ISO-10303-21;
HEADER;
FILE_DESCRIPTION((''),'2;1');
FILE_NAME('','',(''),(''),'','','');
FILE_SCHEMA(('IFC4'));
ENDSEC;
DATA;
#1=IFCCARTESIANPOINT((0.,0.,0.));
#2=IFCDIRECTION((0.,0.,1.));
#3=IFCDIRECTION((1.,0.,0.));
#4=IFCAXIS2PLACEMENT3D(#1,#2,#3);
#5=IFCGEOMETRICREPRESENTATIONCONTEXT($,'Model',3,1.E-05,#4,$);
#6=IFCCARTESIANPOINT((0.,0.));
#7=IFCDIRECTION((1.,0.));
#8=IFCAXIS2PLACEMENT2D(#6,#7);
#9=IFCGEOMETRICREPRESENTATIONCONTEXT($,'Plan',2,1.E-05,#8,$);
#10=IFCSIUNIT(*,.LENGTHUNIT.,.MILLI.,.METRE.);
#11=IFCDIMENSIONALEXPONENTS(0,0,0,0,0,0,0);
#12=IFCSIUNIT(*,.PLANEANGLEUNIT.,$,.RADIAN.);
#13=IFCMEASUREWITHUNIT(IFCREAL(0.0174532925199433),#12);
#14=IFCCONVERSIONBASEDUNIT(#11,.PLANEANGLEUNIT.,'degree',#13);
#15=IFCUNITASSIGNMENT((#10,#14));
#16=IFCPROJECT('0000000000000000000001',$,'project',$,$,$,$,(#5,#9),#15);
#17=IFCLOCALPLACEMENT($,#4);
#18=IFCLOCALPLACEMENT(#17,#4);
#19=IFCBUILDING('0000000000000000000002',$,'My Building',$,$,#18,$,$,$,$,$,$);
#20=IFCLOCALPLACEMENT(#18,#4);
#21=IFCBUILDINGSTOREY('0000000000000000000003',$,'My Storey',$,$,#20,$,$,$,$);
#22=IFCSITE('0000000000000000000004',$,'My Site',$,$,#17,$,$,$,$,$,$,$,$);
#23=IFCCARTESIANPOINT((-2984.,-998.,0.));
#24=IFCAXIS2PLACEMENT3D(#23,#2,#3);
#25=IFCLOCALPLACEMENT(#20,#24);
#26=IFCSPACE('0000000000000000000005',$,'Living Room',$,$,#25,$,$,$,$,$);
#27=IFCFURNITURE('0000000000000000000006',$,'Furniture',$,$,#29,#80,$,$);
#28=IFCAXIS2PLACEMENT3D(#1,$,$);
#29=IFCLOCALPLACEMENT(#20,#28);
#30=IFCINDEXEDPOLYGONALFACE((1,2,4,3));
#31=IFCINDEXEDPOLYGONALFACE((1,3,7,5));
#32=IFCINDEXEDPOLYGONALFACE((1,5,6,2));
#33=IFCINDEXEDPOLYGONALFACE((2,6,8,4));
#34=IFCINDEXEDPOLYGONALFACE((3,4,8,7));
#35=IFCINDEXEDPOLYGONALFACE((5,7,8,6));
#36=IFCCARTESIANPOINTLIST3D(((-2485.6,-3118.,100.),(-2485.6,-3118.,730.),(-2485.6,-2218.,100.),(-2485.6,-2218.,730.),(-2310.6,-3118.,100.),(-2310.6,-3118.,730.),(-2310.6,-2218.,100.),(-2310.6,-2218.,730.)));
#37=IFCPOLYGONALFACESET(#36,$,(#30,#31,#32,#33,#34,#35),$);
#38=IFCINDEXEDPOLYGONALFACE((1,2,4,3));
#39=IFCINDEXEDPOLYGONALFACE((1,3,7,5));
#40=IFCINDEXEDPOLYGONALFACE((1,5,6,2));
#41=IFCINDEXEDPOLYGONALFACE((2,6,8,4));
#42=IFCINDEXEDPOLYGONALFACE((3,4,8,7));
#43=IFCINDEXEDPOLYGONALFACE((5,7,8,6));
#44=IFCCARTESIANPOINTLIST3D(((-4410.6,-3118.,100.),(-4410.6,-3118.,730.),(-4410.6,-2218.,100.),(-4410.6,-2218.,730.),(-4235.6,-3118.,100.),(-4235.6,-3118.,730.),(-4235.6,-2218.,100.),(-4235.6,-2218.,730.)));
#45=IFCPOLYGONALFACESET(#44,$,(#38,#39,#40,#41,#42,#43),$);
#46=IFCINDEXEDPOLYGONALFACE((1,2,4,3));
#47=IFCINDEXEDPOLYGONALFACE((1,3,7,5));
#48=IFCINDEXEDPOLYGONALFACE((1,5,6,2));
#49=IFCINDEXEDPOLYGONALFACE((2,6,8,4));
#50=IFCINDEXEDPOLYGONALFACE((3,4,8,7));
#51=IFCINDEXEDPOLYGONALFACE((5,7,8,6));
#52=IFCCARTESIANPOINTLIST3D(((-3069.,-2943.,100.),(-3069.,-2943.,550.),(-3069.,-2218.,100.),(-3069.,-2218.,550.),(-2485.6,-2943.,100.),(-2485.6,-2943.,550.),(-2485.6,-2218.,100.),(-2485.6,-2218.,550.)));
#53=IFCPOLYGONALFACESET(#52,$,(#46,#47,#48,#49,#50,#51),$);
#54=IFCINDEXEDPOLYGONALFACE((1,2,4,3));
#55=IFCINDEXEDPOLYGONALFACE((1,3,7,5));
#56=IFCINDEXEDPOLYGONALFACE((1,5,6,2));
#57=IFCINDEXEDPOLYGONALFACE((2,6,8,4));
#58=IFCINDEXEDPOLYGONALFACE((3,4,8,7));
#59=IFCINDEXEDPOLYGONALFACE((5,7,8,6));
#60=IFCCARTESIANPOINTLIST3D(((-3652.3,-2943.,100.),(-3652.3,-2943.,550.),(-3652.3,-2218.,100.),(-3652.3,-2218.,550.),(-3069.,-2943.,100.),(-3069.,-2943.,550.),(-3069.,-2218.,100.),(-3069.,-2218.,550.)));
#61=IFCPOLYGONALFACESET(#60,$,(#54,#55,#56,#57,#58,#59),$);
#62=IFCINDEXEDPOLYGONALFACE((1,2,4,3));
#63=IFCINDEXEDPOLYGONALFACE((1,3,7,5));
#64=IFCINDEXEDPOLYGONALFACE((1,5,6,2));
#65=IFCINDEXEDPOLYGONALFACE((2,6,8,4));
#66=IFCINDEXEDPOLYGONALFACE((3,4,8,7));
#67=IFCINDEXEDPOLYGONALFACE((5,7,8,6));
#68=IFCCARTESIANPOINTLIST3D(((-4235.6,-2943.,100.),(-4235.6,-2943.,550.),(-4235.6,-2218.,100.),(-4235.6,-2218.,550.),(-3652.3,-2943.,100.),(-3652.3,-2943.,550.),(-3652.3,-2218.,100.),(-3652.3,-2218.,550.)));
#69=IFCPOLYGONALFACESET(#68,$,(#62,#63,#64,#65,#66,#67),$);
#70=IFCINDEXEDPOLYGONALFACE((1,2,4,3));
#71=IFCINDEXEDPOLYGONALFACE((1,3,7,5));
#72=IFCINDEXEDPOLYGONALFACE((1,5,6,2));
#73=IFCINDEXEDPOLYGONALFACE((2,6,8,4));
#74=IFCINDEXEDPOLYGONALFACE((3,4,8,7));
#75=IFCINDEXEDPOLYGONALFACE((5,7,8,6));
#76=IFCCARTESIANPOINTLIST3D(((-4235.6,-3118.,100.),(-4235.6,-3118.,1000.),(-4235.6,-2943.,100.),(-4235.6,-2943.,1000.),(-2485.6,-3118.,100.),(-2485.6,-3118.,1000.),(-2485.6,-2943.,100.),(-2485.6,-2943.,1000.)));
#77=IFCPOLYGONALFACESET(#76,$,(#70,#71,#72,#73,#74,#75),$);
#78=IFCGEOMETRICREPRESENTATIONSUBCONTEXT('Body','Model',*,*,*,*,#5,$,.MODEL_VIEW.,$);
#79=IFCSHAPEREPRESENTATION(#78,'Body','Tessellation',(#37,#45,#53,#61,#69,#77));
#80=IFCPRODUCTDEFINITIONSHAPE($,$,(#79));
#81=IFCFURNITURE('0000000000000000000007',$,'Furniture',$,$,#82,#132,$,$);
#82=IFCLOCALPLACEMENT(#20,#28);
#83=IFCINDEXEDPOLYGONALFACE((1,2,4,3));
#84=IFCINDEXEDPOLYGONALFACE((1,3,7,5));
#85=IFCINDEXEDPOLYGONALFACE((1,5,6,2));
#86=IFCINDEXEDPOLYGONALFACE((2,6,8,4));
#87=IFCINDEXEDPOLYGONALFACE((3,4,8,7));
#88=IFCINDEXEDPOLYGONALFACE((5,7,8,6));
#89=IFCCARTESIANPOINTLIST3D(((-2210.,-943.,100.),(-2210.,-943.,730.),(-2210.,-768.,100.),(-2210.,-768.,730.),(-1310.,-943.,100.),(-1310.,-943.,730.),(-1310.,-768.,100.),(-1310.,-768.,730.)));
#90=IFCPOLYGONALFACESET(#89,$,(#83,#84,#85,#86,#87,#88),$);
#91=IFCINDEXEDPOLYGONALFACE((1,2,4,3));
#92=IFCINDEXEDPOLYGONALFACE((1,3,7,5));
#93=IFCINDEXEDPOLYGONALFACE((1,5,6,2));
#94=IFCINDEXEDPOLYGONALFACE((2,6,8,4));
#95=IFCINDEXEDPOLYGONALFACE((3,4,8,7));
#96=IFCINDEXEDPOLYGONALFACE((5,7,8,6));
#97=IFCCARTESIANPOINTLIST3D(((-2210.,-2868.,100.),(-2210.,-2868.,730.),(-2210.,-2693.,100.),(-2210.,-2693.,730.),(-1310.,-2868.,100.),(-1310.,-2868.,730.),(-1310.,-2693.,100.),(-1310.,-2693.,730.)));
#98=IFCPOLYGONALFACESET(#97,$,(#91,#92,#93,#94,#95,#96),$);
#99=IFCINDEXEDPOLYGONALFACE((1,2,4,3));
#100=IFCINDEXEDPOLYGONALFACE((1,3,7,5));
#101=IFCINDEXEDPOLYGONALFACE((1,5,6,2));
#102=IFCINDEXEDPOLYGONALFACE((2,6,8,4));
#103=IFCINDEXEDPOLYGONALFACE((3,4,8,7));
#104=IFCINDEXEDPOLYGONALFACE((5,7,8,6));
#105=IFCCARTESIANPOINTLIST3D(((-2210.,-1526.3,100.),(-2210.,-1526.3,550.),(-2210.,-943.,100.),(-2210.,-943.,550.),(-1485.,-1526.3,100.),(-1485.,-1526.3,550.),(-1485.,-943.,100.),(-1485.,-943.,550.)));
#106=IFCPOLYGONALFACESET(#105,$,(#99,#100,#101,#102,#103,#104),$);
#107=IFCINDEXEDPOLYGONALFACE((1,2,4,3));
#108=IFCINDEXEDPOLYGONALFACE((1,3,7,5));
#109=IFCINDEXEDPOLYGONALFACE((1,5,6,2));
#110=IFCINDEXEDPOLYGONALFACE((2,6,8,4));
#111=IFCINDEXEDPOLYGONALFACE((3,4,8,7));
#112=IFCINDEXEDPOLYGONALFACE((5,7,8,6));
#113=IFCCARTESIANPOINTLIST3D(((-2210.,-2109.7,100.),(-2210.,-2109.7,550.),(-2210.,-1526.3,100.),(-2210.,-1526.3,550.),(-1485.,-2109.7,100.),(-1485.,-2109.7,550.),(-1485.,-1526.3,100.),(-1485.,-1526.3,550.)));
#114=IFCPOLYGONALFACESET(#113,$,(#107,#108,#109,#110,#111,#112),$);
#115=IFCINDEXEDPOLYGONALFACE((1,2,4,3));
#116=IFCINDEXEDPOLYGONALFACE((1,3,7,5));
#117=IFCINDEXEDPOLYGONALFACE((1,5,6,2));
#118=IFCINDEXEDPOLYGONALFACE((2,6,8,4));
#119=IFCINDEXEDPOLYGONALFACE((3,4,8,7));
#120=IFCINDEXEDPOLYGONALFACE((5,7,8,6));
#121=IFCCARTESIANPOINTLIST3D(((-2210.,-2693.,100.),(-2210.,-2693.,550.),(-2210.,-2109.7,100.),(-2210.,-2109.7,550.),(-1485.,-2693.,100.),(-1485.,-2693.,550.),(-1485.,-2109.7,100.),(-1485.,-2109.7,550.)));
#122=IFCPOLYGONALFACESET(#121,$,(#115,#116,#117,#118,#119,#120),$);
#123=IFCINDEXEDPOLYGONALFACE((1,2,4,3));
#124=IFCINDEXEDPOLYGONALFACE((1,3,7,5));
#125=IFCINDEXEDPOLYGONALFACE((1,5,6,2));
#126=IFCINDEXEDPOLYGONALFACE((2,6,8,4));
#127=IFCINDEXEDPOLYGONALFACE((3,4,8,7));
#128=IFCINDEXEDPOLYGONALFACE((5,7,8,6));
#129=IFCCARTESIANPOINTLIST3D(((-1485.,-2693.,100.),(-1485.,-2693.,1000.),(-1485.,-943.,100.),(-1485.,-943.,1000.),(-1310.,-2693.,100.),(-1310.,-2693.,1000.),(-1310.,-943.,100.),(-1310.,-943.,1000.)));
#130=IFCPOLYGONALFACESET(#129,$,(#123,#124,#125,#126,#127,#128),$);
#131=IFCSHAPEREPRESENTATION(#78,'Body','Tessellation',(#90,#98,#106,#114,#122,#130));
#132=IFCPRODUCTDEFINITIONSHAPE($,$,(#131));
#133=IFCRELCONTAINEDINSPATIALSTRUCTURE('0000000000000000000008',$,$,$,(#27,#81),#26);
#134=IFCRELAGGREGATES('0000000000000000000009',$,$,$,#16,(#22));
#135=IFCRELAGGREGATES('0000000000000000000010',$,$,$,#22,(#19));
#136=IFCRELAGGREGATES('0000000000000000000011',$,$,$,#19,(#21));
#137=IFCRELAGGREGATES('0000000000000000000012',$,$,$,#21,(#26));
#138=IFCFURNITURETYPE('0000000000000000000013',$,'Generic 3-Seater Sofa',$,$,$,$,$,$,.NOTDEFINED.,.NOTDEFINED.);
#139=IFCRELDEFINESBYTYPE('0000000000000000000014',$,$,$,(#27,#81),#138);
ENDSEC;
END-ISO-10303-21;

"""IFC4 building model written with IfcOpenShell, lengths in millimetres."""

from ifc_helpers import new_model, entity, si_unit, converted_unit, frame, origin_with_axes, origin_2d_with_axis, place, context, subcontext, project, spatial, line, indexed_curve, outline, extrude, shape, source, transform, mapped, type_object, type_shapes, element, save


model = new_model("IFC4")

# Units and contexts
model_context = context("Model", 3, precision=1e-05, world=origin_with_axes())
plan_context = context("Plan", 2, precision=1e-05, world=origin_2d_with_axis())
body_context_1 = subcontext(model_context, "Body", "Model", "MODEL_VIEW")
body_context_2 = subcontext(plan_context, "Body", "Plan", "PLAN_VIEW")
ifc_project = project(units=[si_unit("LENGTHUNIT", "METRE", prefix="MILLI"), converted_unit("PLANEANGLEUNIT", "degree", entity("IfcReal", 0.0174532925199433), si_unit("PLANEANGLEUNIT", "RADIAN"), dimensions=[0, 0, 0, 0, 0, 0, 0])], contexts=[model_context, plan_context])

# Site, building, storey
site_placement = place(None, origin_with_axes())
site = spatial("IfcSite", under=ifc_project, at=site_placement, Name="My Site")
building_placement = place(site_placement, origin_with_axes())
building = spatial("IfcBuilding", under=site, at=building_placement, Name="My Building")
storey_placement = place(building_placement, origin_with_axes())
storey = spatial("IfcBuildingStorey", under=building, at=storey_placement, Name="My Storey")

# Shared definitions
space_1_placement = place(storey_placement, frame((-2984.0, -998.0, 0.0), z_axis=(0.0, 0.0, 1.0), x_axis=(1.0, 0.0, 0.0)))
space_1 = spatial("IfcSpace", under=storey, at=space_1_placement, Name="Living Room")

# Furniture
furniture_type_1 = type_object("IfcFurnitureType", Name="Generic 3-Seater Sofa", AssemblyPlace="NOTDEFINED", PredefinedType="NOTDEFINED")
shared_shape_1 = source(origin_with_axes(), body_context_1, "Body", "SweptSolid", [
    extrude(outline(indexed_curve([(0.0, 0.0), (175.0, 0.0), (175.0, 900.0), (0.0, 900.0)], segments=[line(1, 2, 3, 4, 1)])), frame((-1050.0, -900.0, 0.0), z_axis=(0.0, 0.0, 1.0), x_axis=(1.0, 0.0, 0.0)), (0.0, 0.0, 1.0), 630.0),
    extrude(outline(indexed_curve([(0.0, 0.0), (175.0, 0.0), (175.0, 900.0), (0.0, 900.0)], segments=[line(1, 2, 3, 4, 1)])), frame((875.0, -900.0, 0.0), z_axis=(0.0, 0.0, 1.0), x_axis=(1.0, 0.0, 0.0)), (0.0, 0.0, 1.0), 630.0),
    extrude(outline(indexed_curve([(175.0, 0.0), (758.3, 0.0), (758.3, 725.0), (175.0, 725.0)], segments=[line(1, 2, 3, 4, 1)])), frame((-1050.0, -900.0, 0.0), z_axis=(0.0, 0.0, 1.0), x_axis=(1.0, 0.0, 0.0)), (0.0, 0.0, 1.0), 450.0),
    extrude(outline(indexed_curve([(758.3, 0.0), (1341.7, 0.0), (1341.7, 725.0), (758.3, 725.0)], segments=[line(1, 2, 3, 4, 1)])), frame((-1050.0, -900.0, 0.0), z_axis=(0.0, 0.0, 1.0), x_axis=(1.0, 0.0, 0.0)), (0.0, 0.0, 1.0), 450.0),
    extrude(outline(indexed_curve([(1341.7, 0.0), (1925.0, 0.0), (1925.0, 725.0), (1341.7, 725.0)], segments=[line(1, 2, 3, 4, 1)])), frame((-1050.0, -900.0, 0.0), z_axis=(0.0, 0.0, 1.0), x_axis=(1.0, 0.0, 0.0)), (0.0, 0.0, 1.0), 450.0),
    extrude(outline(indexed_curve([(175.0, 725.0), (1925.0, 725.0), (1925.0, 900.0), (175.0, 900.0)], segments=[line(1, 2, 3, 4, 1)])), frame((-1050.0, -900.0, 0.0), z_axis=(0.0, 0.0, 1.0), x_axis=(1.0, 0.0, 0.0)), (0.0, 0.0, 1.0), 900.0),
])
shared_shape_2 = source(origin_with_axes(), body_context_2, "Body", "Curve2D", [
    entity("IfcIndexedPolyCurve", entity("IfcCartesianPointList2D", [[-1050.0, -900.0], [-875.0, -900.0], [-875.0, 0.0], [-1050.0, 0.0]]), [entity("IfcLineIndex", [1, 2, 3, 4, 1])]),
    entity("IfcIndexedPolyCurve", entity("IfcCartesianPointList2D", [[875.0, -900.0], [1050.0, -900.0], [1050.0, 0.0], [875.0, 0.0]]), [entity("IfcLineIndex", [1, 2, 3, 4, 1])]),
    entity("IfcIndexedPolyCurve", entity("IfcCartesianPointList2D", [[-875.0, -900.0], [-291.7, -900.0], [-291.7, -175.0], [-875.0, -175.0]]), [entity("IfcLineIndex", [1, 2, 3, 4, 1])]),
    entity("IfcIndexedPolyCurve", entity("IfcCartesianPointList2D", [[-291.7, -900.0], [291.7, -900.0], [291.7, -175.0], [-291.7, -175.0]]), [entity("IfcLineIndex", [1, 2, 3, 4, 1])]),
    entity("IfcIndexedPolyCurve", entity("IfcCartesianPointList2D", [[291.7, -900.0], [875.0, -900.0], [875.0, -175.0], [291.7, -175.0]]), [entity("IfcLineIndex", [1, 2, 3, 4, 1])]),
    entity("IfcIndexedPolyCurve", entity("IfcCartesianPointList2D", [[-875.0, -175.0], [875.0, -175.0], [875.0, 0.0], [-875.0, 0.0]]), [entity("IfcLineIndex", [1, 2, 3, 4, 1])]),
])
type_shapes(furniture_type_1, [shared_shape_1, shared_shape_2])
for number, where, z_axis, x_axis, name in (
    (1, (-376.6, -2120.0, 100.0), (0.0, 0.0, 1.0), (-1.0, 0.0, 0.0), "Furniture"),
    (2, (1674.0, -820.0, 100.0), (0.0, 0.0, 1.0), (0.000001, -1.0, 0.0), "Furniture"),
):
    element("IfcFurniture", number, at=place(space_1_placement, frame(where, z_axis=z_axis, x_axis=x_axis)), inside=space_1, type_object=furniture_type_1, Name=name, shapes=[
        shape(body_context_1, "Body", "MappedRepresentation", [mapped(shared_shape_1, transform((0.0, 0.0, 0.0), x_axis=(1.0, 0.0, 0.0), y_axis=(0.0, 1.0, 0.0), z_axis=(0.0, 0.0, 1.0), scale=1.0))]),
        shape(body_context_2, "Body", "MappedRepresentation", [mapped(shared_shape_2, transform((0.0, 0.0, 0.0), x_axis=(1.0, 0.0, 0.0), y_axis=(0.0, 1.0, 0.0), z_axis=(0.0, 0.0, 1.0), scale=1.0))]),
    ])

save(model, "model.ifc")
